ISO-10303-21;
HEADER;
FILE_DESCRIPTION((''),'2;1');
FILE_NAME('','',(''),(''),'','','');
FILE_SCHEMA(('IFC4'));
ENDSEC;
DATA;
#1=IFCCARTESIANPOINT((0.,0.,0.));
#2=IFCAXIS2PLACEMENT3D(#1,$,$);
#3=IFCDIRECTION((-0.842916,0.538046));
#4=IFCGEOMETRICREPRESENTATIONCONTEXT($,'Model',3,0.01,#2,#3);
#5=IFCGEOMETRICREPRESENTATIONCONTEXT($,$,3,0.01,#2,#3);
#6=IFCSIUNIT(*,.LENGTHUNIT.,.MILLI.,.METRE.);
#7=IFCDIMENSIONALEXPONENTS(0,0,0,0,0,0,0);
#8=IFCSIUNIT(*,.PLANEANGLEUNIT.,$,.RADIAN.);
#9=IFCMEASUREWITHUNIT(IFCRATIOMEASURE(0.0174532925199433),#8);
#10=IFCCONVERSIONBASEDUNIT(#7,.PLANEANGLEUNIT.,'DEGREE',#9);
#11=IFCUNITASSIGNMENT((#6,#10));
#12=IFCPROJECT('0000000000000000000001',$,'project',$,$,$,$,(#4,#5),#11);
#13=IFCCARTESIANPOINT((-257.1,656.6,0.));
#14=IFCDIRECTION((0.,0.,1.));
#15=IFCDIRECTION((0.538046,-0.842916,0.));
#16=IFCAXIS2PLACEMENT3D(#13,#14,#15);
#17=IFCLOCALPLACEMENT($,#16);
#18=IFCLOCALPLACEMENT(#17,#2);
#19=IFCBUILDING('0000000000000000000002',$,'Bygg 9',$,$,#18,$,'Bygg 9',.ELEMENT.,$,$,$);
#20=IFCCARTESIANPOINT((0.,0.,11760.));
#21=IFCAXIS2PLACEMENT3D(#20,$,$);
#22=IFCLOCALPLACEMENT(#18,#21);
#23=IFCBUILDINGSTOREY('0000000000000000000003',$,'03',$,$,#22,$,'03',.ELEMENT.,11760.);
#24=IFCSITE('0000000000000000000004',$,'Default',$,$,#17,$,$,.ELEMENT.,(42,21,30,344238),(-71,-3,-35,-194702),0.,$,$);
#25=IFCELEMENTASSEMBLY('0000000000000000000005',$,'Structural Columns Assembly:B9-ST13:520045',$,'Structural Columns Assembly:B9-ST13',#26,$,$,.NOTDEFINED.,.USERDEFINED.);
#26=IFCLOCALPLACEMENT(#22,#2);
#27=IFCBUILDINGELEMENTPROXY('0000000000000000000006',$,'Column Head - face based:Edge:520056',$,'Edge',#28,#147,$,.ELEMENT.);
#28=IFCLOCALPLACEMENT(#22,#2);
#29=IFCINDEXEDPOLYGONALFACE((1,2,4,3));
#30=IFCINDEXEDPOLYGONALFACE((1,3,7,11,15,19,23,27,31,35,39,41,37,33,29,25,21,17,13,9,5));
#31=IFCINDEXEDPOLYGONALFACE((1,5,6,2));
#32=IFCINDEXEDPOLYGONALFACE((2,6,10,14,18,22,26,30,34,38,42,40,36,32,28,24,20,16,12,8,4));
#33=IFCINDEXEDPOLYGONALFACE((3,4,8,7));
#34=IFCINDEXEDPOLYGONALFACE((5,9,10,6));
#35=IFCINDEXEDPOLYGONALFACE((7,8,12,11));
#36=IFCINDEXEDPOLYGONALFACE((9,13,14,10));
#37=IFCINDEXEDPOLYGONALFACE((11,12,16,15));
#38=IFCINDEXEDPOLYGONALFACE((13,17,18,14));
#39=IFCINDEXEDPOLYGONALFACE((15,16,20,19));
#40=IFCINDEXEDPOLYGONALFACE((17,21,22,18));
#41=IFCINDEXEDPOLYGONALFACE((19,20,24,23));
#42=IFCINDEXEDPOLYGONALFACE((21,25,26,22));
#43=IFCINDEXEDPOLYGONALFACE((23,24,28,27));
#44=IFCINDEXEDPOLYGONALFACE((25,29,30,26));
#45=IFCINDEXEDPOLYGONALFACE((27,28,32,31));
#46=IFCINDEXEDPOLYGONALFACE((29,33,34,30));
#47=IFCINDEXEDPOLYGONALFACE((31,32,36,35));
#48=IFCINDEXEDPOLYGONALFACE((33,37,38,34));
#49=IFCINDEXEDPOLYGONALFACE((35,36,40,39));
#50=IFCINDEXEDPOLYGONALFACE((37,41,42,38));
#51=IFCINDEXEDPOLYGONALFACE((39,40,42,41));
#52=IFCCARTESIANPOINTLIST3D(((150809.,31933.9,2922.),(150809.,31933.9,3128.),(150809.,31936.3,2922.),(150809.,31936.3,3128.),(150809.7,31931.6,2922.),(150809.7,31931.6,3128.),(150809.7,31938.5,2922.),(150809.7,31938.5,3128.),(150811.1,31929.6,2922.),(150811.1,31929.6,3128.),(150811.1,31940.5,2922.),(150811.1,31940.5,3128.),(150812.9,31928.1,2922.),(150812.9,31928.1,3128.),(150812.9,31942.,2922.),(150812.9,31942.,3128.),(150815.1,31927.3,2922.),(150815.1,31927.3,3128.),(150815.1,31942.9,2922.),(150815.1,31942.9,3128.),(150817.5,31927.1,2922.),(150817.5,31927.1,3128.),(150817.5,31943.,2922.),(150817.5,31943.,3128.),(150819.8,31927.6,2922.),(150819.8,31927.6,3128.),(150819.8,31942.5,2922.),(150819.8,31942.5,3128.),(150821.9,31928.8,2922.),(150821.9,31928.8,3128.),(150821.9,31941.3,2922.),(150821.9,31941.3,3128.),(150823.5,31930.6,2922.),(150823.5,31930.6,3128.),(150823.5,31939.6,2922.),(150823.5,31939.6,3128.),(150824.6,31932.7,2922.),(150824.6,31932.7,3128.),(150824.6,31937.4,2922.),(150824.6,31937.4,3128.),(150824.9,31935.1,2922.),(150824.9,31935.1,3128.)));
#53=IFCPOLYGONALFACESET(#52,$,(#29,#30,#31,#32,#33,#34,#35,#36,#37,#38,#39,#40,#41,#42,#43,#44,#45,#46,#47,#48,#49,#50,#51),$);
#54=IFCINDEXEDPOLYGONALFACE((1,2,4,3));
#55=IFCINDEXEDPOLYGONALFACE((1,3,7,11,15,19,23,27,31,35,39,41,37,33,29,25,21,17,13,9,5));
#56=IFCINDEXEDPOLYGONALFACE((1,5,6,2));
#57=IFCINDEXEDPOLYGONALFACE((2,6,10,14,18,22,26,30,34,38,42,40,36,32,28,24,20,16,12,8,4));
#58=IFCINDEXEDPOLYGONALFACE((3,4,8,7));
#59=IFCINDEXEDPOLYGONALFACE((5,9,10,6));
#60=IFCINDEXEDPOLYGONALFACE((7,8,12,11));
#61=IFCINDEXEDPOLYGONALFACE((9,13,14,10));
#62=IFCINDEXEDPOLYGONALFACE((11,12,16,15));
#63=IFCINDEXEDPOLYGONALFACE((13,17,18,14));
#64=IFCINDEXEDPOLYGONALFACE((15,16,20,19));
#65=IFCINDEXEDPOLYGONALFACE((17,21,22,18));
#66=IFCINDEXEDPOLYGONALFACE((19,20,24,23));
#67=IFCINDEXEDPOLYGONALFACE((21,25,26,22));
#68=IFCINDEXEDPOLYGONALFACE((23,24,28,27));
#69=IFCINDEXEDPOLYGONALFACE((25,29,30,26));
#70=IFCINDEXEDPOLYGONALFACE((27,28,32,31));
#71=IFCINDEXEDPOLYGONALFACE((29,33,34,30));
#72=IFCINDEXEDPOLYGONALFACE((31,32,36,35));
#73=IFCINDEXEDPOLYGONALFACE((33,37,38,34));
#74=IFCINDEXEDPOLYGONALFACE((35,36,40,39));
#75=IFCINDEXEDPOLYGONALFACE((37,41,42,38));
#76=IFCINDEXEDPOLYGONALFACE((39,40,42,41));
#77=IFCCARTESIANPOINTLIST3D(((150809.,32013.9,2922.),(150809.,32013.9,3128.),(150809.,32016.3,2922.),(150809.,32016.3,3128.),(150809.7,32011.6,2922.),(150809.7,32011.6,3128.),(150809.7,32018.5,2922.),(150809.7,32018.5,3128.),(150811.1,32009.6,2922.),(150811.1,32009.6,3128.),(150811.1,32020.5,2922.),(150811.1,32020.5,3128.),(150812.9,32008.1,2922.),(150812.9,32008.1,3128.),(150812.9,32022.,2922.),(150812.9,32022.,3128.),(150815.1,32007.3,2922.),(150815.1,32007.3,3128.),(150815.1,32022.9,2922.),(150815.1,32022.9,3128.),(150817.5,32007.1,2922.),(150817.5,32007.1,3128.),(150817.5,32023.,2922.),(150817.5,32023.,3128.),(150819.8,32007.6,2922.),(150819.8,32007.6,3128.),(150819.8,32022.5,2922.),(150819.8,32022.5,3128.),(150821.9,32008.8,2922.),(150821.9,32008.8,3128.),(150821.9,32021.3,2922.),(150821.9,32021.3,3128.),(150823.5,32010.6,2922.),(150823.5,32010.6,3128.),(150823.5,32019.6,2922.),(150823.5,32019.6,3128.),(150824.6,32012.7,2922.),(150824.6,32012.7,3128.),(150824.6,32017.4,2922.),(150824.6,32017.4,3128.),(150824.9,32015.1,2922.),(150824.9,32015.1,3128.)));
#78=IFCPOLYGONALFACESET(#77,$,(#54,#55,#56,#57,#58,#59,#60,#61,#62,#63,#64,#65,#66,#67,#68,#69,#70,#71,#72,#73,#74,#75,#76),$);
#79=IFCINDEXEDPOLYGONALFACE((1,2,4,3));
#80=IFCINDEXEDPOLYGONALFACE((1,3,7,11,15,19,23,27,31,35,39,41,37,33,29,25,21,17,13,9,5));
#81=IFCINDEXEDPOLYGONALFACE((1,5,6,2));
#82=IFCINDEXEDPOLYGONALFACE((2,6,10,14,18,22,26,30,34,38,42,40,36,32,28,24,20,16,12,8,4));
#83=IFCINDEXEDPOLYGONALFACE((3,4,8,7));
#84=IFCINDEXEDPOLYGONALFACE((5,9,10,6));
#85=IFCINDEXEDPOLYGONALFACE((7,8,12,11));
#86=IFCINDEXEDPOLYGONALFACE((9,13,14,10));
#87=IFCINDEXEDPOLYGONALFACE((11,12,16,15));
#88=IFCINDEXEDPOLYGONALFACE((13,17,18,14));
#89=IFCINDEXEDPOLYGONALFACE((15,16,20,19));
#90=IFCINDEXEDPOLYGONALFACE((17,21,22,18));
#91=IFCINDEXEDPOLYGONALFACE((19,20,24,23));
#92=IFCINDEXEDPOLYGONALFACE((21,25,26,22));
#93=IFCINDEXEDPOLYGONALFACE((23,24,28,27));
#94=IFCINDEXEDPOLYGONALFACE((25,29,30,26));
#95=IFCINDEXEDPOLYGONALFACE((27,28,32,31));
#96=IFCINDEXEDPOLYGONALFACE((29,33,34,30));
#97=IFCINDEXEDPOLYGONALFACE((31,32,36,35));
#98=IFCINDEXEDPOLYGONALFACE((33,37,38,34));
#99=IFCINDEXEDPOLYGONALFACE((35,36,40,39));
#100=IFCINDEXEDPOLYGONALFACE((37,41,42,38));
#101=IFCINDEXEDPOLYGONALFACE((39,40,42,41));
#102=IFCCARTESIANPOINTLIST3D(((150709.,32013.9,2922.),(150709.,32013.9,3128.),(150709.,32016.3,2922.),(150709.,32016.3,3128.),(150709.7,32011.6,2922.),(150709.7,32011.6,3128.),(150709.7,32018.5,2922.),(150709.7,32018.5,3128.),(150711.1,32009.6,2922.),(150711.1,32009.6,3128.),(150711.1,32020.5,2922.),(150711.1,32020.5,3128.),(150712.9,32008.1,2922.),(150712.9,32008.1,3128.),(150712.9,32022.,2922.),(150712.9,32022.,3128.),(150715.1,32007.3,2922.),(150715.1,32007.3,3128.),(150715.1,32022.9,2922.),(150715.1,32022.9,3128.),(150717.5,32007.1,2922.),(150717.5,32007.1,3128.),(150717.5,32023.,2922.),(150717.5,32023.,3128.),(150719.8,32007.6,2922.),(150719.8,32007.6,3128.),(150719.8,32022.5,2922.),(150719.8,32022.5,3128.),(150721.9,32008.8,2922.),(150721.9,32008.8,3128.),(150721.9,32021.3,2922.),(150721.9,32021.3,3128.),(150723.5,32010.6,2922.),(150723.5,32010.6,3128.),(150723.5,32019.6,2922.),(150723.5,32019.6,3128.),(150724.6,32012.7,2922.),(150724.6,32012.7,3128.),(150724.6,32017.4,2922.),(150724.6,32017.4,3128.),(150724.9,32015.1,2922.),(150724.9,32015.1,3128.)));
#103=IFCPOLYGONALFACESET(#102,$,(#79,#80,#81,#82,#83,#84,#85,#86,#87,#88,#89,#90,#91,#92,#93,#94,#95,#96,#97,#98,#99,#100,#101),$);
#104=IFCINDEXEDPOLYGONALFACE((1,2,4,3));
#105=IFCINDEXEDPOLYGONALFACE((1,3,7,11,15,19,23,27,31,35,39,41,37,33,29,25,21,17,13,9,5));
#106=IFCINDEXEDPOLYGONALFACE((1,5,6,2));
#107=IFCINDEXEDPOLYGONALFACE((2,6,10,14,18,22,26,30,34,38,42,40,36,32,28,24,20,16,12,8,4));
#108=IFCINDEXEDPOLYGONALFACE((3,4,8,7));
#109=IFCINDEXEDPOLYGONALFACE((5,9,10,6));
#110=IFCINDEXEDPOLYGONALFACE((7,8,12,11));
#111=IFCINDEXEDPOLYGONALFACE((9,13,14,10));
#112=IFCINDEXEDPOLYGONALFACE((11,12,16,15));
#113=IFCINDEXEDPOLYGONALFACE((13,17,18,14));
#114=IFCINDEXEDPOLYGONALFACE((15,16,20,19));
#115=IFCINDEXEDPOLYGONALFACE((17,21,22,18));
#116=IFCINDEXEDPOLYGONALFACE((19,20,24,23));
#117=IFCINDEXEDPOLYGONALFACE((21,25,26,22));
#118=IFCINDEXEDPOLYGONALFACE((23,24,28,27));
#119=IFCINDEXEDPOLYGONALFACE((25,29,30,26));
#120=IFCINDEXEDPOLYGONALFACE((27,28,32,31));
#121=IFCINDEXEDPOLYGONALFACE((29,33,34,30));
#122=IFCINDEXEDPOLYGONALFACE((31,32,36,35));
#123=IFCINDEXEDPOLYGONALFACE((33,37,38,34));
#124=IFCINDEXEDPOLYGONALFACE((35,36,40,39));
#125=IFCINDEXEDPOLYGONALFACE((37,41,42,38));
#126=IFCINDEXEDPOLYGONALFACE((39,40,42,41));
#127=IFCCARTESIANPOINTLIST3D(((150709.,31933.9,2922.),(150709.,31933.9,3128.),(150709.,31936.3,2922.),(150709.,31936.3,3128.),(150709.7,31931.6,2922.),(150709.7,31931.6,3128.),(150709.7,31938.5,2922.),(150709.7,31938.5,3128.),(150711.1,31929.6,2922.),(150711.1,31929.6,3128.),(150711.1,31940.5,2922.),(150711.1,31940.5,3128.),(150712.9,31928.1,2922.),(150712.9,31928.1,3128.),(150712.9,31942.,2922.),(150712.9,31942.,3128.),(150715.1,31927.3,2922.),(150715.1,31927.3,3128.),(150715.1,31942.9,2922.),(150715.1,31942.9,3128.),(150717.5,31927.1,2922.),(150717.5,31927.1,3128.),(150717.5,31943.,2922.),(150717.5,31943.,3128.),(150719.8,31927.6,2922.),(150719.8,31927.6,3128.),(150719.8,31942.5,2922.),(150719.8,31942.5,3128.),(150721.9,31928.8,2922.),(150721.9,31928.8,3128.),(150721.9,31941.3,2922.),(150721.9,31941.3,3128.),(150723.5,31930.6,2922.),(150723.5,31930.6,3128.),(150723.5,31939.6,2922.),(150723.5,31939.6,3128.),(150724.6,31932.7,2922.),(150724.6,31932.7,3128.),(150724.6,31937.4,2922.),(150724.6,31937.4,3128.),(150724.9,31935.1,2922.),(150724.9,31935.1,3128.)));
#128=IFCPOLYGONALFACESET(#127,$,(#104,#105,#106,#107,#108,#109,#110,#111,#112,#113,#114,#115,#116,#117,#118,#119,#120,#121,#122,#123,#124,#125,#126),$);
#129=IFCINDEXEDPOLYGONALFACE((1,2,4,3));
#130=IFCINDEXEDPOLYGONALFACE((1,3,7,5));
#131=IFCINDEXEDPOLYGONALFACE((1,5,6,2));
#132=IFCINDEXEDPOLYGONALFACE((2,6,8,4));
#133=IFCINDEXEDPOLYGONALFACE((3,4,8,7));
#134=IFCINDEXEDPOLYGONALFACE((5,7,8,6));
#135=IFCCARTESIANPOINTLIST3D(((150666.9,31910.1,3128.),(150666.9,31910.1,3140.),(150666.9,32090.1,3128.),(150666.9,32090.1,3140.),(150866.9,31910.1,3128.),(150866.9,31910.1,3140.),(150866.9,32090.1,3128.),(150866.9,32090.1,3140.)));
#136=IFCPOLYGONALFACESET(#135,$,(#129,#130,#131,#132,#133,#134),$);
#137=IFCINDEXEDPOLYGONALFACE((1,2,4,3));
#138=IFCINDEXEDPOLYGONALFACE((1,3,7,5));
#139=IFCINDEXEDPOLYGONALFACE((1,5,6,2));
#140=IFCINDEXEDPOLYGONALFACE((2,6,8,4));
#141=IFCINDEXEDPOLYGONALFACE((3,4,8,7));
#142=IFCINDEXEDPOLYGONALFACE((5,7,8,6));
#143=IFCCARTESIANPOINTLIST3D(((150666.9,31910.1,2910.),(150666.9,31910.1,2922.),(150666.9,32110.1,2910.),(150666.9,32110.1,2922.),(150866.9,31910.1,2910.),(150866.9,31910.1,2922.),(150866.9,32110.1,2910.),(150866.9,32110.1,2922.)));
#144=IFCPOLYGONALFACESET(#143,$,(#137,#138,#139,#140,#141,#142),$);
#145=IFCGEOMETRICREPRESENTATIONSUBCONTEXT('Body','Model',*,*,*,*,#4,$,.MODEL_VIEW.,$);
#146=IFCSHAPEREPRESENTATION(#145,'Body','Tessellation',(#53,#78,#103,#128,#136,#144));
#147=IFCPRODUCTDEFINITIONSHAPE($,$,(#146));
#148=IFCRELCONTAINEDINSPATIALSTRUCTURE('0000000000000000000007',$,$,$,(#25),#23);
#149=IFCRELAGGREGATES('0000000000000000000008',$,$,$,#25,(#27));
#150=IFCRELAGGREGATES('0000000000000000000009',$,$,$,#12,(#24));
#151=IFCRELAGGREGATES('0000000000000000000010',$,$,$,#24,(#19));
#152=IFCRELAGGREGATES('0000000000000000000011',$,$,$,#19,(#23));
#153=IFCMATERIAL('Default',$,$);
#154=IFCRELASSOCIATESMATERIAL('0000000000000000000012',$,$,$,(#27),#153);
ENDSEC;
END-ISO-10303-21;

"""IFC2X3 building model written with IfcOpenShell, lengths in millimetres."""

from ifc_helpers import new_model, entity, si_unit, converted_unit, direction, frame, frame_2d, origin, origin_2d_with_axis, place, context, subcontext, project, spatial, rectangle, circle, extrude, source, transform, mapped, material, element, aggregate, save


model = new_model("IFC2X3")

# Units and contexts
model_context = context("Model", 3, precision=0.01, world=origin(), true_north=direction((-0.842916, 0.538046)))
context_of_model = context(None, 3, precision=0.01, world=origin(), true_north=direction((-0.842916, 0.538046)))
body_context = subcontext(model_context, "Body", "Model", "MODEL_VIEW")
ifc_project = project(units=[si_unit("LENGTHUNIT", "METRE", prefix="MILLI"), converted_unit("PLANEANGLEUNIT", "DEGREE", entity("IfcRatioMeasure", 0.0174532925199433), si_unit("PLANEANGLEUNIT", "RADIAN"), dimensions=[0, 0, 0, 0, 0, 0, 0])], contexts=[model_context, context_of_model])

# Site, building, storey
site_placement = place(None, frame((-257.1, 656.6, 0.0), z_axis=(0.0, 0.0, 1.0), x_axis=(0.538046, -0.842916, 0.0)))
site = spatial("IfcSite", under=ifc_project, at=site_placement, Name="Default", CompositionType="ELEMENT", RefLatitude=(42, 21, 30, 344238), RefLongitude=(-71, -3, -35, -194702), RefElevation=0.0)
building_placement = place(site_placement, origin())
building = spatial("IfcBuilding", under=site, at=building_placement, Name="Bygg 9", LongName="Bygg 9", CompositionType="ELEMENT")
storey_placement = place(building_placement, frame((0.0, 0.0, 11760.0)))
storey = spatial("IfcBuildingStorey", under=building, at=storey_placement, Name="03", LongName="03", CompositionType="ELEMENT", Elevation=11760.0)

# Shared definitions
ifc_material_1 = material(Name="Default")

# Element assembly, building element proxy
shared_shape_1 = source(origin(), body_context, "Body", "SweptSolid", [
    extrude(circle(Radius=8.0, at=frame_2d((0.0, 0.0), x_axis=(1.0, 0.0))), frame((50.0, -135.0, 12.0)), (0.0, 0.0, 1.0), 206.0),
    extrude(circle(Radius=8.0, at=frame_2d((0.0, 0.0), x_axis=(1.0, 0.0))), frame((50.0, -55.0, 12.0)), (0.0, 0.0, 1.0), 206.0),
    extrude(circle(Radius=8.0, at=frame_2d((0.0, 0.0), x_axis=(1.0, 0.0))), frame((-50.0, -55.0, 12.0)), (0.0, 0.0, 1.0), 206.0),
    extrude(circle(Radius=8.0, at=frame_2d((0.0, 0.0), x_axis=(1.0, 0.0))), frame((-50.0, -135.0, 12.0)), (0.0, 0.0, 1.0), 206.0),
    extrude(rectangle(XDim=200.0, YDim=180.0, at=origin_2d_with_axis()), frame((0.0, -70.0, 218.0), z_axis=(0.0, 0.0, 1.0), x_axis=(-1.0, 0.0, 0.0)), (0.0, 0.0, 1.0), 12.0),
    extrude(rectangle(XDim=200.0, YDim=200.0, at=origin_2d_with_axis()), frame((0.0, -60.0, 0.0), z_axis=(0.0, 0.0, 1.0), x_axis=(0.0, 1.0, 0.0)), (0.0, 0.0, 1.0), 12.0),
])
assembly_1_placement = place(storey_placement, origin())
assembly_1 = element("IfcElementAssembly", 1, at=assembly_1_placement, inside=storey, Name="Structural Columns Assembly:B9-ST13:520045", ObjectType="Structural Columns Assembly:B9-ST13", AssemblyPlace="NOTDEFINED", PredefinedType="USERDEFINED")
proxy_1_placement = place(assembly_1_placement, frame((150766.9, 32070.1, 2910.0)))
proxy_1 = element("IfcBuildingElementProxy", 2, at=proxy_1_placement, material=ifc_material_1, Name="Column Head - face based:Edge:520056", ObjectType="Edge", CompositionType="ELEMENT", context=body_context, shape_type="MappedRepresentation", body=[
    mapped(shared_shape_1, transform((0.0, 0.0, 0.0), scale=1.0)),
])
aggregate(assembly_1, [proxy_1])

save(model, "model.ifc")
